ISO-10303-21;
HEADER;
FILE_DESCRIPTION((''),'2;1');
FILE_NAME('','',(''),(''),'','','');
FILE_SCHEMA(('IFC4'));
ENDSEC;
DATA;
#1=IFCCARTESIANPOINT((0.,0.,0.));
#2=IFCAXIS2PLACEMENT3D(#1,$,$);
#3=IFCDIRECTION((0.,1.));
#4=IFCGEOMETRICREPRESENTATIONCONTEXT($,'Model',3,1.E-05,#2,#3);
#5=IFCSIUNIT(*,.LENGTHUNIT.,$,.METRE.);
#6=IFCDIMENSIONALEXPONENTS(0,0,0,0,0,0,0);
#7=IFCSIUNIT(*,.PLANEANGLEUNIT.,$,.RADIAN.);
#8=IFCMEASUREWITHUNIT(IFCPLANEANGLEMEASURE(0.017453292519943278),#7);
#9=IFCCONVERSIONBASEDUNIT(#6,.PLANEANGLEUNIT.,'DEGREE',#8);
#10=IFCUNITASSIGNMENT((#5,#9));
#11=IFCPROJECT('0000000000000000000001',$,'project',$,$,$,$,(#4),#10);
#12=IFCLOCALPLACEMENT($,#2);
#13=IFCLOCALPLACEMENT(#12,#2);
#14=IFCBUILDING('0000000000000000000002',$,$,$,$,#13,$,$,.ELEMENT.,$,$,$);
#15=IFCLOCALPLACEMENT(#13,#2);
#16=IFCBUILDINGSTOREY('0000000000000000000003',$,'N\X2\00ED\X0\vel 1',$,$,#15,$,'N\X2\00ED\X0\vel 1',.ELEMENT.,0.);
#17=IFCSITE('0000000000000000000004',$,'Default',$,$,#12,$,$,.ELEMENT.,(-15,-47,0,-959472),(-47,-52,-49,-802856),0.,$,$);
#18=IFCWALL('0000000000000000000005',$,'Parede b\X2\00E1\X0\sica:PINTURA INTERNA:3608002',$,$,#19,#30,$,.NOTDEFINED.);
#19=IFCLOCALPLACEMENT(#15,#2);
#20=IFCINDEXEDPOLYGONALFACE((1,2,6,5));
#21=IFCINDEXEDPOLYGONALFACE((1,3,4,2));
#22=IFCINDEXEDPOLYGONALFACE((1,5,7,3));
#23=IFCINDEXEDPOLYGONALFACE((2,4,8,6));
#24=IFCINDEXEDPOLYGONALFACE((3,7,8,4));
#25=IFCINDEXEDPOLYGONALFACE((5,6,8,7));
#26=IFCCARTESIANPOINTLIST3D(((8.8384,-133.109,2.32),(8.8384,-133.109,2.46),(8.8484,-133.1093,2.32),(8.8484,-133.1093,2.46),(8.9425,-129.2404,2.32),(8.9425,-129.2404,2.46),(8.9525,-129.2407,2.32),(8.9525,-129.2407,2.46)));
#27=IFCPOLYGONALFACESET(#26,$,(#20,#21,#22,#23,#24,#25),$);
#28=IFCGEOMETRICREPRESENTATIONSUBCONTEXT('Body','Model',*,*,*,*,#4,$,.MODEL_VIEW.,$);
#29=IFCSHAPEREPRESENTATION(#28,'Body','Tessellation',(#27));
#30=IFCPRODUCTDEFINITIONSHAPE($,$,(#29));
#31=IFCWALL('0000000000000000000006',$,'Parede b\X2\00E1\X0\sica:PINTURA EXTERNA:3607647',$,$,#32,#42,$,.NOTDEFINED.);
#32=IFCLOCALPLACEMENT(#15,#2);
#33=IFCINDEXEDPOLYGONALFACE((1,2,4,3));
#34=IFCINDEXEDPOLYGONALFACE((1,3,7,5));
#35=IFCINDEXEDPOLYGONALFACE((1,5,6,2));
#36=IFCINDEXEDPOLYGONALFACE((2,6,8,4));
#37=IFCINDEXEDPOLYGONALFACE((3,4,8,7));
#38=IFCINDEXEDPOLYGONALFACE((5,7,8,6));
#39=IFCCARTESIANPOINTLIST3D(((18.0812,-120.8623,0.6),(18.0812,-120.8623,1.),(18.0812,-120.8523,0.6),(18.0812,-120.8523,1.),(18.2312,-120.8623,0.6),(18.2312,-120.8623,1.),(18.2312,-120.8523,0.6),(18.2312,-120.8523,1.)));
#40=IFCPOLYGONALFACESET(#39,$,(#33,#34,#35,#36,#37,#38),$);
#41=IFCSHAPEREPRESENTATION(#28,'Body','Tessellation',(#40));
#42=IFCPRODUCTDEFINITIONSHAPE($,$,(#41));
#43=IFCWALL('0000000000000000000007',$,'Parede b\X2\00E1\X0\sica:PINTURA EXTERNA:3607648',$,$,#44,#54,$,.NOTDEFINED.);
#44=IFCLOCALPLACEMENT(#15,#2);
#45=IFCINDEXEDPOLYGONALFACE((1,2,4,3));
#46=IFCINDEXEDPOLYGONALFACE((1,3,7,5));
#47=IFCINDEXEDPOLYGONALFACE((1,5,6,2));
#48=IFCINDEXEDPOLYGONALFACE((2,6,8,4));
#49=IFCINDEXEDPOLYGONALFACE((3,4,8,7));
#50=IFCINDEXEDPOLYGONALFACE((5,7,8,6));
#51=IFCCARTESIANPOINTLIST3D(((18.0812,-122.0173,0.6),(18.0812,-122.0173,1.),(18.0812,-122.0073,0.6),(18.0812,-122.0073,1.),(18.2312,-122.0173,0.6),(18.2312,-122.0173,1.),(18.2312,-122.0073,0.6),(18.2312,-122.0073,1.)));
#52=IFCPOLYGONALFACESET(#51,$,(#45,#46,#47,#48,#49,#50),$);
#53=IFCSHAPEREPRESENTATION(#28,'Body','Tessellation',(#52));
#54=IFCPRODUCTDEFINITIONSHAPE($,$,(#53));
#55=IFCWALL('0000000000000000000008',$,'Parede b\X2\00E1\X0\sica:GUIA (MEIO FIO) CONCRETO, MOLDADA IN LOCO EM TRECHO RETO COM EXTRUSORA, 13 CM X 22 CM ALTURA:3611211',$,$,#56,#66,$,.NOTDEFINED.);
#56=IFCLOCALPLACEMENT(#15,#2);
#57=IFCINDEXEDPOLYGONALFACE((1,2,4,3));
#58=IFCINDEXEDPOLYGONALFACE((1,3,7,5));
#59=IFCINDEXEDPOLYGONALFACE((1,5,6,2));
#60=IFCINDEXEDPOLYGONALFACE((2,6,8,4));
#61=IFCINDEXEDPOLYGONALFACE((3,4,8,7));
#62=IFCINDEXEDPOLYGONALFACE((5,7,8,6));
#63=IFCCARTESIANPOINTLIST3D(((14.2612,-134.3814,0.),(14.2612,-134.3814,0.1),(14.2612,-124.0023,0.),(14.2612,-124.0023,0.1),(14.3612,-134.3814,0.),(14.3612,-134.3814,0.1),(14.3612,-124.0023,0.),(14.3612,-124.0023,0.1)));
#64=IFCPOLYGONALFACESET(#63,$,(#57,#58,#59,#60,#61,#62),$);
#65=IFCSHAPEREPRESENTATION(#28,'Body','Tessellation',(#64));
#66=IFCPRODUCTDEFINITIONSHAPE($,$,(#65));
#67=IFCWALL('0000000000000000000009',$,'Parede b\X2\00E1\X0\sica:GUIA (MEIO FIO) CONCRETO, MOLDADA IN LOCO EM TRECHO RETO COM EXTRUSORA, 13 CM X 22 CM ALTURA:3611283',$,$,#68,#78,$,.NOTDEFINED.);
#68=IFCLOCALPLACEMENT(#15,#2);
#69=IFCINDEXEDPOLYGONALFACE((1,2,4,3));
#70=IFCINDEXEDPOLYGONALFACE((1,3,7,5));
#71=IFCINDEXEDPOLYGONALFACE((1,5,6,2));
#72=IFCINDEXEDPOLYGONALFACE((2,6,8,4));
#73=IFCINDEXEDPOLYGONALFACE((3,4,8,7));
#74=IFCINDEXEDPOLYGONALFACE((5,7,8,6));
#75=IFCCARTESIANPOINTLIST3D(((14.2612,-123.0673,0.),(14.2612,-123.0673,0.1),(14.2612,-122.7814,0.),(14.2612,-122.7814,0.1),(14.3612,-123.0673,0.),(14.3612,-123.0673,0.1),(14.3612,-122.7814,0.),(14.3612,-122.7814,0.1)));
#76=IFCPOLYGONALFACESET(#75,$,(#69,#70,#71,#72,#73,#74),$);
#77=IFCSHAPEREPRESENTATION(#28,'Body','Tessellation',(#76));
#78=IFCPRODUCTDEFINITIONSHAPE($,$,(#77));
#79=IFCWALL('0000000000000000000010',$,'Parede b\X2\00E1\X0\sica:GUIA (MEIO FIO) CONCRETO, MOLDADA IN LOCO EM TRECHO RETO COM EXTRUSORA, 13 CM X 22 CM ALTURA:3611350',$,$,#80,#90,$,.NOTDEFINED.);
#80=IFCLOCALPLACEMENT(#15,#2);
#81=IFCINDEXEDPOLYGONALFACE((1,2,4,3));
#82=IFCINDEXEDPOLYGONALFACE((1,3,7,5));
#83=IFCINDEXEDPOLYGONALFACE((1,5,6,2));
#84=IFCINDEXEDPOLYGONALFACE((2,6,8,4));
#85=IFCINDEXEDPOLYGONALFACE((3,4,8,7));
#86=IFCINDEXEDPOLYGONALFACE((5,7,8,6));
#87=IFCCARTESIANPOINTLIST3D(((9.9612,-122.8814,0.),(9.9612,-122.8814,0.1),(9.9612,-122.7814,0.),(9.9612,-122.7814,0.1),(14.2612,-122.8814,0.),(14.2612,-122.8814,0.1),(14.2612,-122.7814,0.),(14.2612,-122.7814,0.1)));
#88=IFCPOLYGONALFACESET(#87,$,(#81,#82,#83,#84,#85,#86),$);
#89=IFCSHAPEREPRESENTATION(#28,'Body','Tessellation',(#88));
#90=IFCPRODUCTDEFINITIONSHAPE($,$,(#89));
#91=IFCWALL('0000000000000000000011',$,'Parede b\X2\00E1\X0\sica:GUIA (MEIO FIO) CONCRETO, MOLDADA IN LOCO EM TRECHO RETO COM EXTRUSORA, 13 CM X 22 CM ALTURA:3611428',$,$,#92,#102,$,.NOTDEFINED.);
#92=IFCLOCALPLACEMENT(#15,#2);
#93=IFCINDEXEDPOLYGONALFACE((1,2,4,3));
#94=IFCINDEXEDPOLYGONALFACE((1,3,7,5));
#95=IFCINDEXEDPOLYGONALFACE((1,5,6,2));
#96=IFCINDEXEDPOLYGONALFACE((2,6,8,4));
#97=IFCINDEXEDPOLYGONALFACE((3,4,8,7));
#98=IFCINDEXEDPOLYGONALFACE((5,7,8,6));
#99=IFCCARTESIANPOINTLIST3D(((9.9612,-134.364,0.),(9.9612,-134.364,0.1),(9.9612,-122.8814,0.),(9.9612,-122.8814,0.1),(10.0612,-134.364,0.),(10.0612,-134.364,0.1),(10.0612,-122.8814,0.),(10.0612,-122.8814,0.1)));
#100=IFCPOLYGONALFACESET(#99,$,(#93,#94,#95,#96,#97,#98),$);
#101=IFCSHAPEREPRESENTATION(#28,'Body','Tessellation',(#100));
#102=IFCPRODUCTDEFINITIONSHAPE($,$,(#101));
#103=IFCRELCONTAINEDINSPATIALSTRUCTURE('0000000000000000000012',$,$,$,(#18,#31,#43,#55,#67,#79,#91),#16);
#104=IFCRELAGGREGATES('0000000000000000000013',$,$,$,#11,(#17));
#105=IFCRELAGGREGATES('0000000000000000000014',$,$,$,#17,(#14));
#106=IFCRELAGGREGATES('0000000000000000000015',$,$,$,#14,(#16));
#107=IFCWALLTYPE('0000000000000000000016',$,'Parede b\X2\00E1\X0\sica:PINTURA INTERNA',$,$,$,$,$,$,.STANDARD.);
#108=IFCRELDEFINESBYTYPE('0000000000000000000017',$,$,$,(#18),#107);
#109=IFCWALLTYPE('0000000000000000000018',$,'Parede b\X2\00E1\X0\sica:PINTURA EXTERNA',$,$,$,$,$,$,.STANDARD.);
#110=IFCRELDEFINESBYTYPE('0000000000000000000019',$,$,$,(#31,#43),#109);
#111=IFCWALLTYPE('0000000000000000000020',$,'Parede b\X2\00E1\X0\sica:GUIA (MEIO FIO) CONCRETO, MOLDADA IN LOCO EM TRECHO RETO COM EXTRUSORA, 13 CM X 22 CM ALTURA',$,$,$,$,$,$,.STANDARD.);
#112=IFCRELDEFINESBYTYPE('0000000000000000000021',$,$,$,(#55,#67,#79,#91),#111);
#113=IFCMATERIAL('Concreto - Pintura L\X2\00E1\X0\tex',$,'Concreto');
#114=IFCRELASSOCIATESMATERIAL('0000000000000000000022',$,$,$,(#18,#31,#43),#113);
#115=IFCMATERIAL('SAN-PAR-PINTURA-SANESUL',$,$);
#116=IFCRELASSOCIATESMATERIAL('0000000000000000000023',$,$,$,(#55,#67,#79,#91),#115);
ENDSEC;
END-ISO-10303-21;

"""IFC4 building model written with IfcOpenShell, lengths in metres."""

from ifc_helpers import new_model, entity, si_unit, converted_unit, direction, frame, origin, place, context, subcontext, project, spatial, indexed_curve, outline, extrude, material, type_object, element, save


model = new_model("IFC4")

# Units and contexts
model_context = context("Model", 3, precision=1e-05, world=origin(), true_north=direction((0.0, 1.0)))
body_context = subcontext(model_context, "Body", "Model", "MODEL_VIEW")
ifc_project = project(units=[si_unit("LENGTHUNIT", "METRE"), converted_unit("PLANEANGLEUNIT", "DEGREE", entity("IfcPlaneAngleMeasure", 0.017453292519943278), si_unit("PLANEANGLEUNIT", "RADIAN"), dimensions=[0, 0, 0, 0, 0, 0, 0])], contexts=[model_context])

# Site, building, storey
site_placement = place(None, origin())
site = spatial("IfcSite", under=ifc_project, at=site_placement, Name="Default", CompositionType="ELEMENT", RefLatitude=(-15, -47, 0, -959472), RefLongitude=(-47, -52, -49, -802856), RefElevation=0.0)
building_placement = place(site_placement, origin())
building = spatial("IfcBuilding", under=site, at=building_placement, CompositionType="ELEMENT")
storey_placement = place(building_placement, origin())
storey = spatial("IfcBuildingStorey", under=building, at=storey_placement, Name="Nível 1", LongName="Nível 1", CompositionType="ELEMENT", Elevation=0.0)

# Shared definitions
ifc_material_1 = material(Name="Concreto - Pintura Látex", Category="Concreto")

# Walls
ifc_material_2 = material(Name="SAN-PAR-PINTURA-SANESUL")
wall_type_1 = type_object("IfcWallType", Name="Parede básica:PINTURA INTERNA", PredefinedType="STANDARD")
wall_1_placement = place(storey_placement, frame((8.8434, -133.1092, 2.32), z_axis=(0.0, 0.0, 1.0), x_axis=(0.026888, 0.999638, 0.0)))
element("IfcWall", 1, at=wall_1_placement, inside=storey, type_object=wall_type_1, material=ifc_material_1, Name="Parede básica:PINTURA INTERNA:3608002", PredefinedType="NOTDEFINED", context=body_context, shape_type="SweptSolid", body=[
    extrude(outline(indexed_curve([(3.87, 0.005), (0.0, 0.005), (0.0, -0.005), (3.87, -0.005), (3.87, 0.005)], self_intersect=False)), origin(), (0.0, 0.0, 1.0), 0.14),
])
wall_type_2 = type_object("IfcWallType", Name="Parede básica:PINTURA EXTERNA", PredefinedType="STANDARD")
wall_2_placement = place(storey_placement, frame((18.0812, -120.8573, 0.6)))
element("IfcWall", 2, at=wall_2_placement, inside=storey, type_object=wall_type_2, material=ifc_material_1, Name="Parede básica:PINTURA EXTERNA:3607647", PredefinedType="NOTDEFINED", context=body_context, shape_type="SweptSolid", body=[
    extrude(outline(indexed_curve([(0.15, 0.005), (0.0, 0.005), (0.0, -0.005), (0.15, -0.005), (0.15, 0.005)], self_intersect=False)), origin(), (0.0, 0.0, 1.0), 0.4),
])
wall_3_placement = place(storey_placement, frame((18.0812, -122.0123, 0.6)))
element("IfcWall", 3, at=wall_3_placement, inside=storey, type_object=wall_type_2, material=ifc_material_1, Name="Parede básica:PINTURA EXTERNA:3607648", PredefinedType="NOTDEFINED", context=body_context, shape_type="SweptSolid", body=[
    extrude(outline(indexed_curve([(0.15, 0.005), (0.0, 0.005), (0.0, -0.005), (0.15, -0.005), (0.15, 0.005)], self_intersect=False)), origin(), (0.0, 0.0, 1.0), 0.4),
])

# Walls
wall_type_3 = type_object("IfcWallType", Name="Parede básica:GUIA (MEIO FIO) CONCRETO, MOLDADA IN LOCO EM TRECHO RETO COM EXTRUSORA, 13 CM X 22 CM ALTURA", PredefinedType="STANDARD")
wall_4_placement = place(storey_placement, frame((14.3112, -134.3814, 0.0), z_axis=(0.0, 0.0, 1.0), x_axis=(0.0, 1.0, 0.0)))
element("IfcWall", 4, at=wall_4_placement, inside=storey, type_object=wall_type_3, material=ifc_material_2, Name="Parede básica:GUIA (MEIO FIO) CONCRETO, MOLDADA IN LOCO EM TRECHO RETO COM EXTRUSORA, 13 CM X 22 CM ALTURA:3611211", PredefinedType="NOTDEFINED", context=body_context, shape_type="SweptSolid", body=[
    extrude(outline(indexed_curve([(10.3791, 0.05), (0.0, 0.05), (0.0, -0.05), (10.3791, -0.05), (10.3791, 0.05)], self_intersect=False)), origin(), (0.0, 0.0, 1.0), 0.1),
])
wall_5_placement = place(storey_placement, frame((14.3112, -123.0673, 0.0), z_axis=(0.0, 0.0, 1.0), x_axis=(0.0, 1.0, 0.0)))
element("IfcWall", 5, at=wall_5_placement, inside=storey, type_object=wall_type_3, material=ifc_material_2, Name="Parede básica:GUIA (MEIO FIO) CONCRETO, MOLDADA IN LOCO EM TRECHO RETO COM EXTRUSORA, 13 CM X 22 CM ALTURA:3611283", PredefinedType="NOTDEFINED", context=body_context, shape_type="SweptSolid", body=[
    extrude(outline(indexed_curve([(0.2859, 0.05), (0.0, 0.05), (0.0, -0.05), (0.2859, -0.05), (0.2859, 0.05)], self_intersect=False)), origin(), (0.0, 0.0, 1.0), 0.1),
])
wall_6_placement = place(storey_placement, frame((14.2612, -122.8314, 0.0), z_axis=(0.0, 0.0, 1.0), x_axis=(-1.0, 0.0, 0.0)))
element("IfcWall", 6, at=wall_6_placement, inside=storey, type_object=wall_type_3, material=ifc_material_2, Name="Parede básica:GUIA (MEIO FIO) CONCRETO, MOLDADA IN LOCO EM TRECHO RETO COM EXTRUSORA, 13 CM X 22 CM ALTURA:3611350", PredefinedType="NOTDEFINED", context=body_context, shape_type="SweptSolid", body=[
    extrude(outline(indexed_curve([(4.3, 0.05), (0.0, 0.05), (0.0, -0.05), (4.3, -0.05), (4.3, 0.05)], self_intersect=False)), origin(), (0.0, 0.0, 1.0), 0.1),
])
wall_7_placement = place(storey_placement, frame((10.0112, -122.8814, 0.0), z_axis=(0.0, 0.0, 1.0), x_axis=(0.0, -1.0, 0.0)))
element("IfcWall", 7, at=wall_7_placement, inside=storey, type_object=wall_type_3, material=ifc_material_2, Name="Parede básica:GUIA (MEIO FIO) CONCRETO, MOLDADA IN LOCO EM TRECHO RETO COM EXTRUSORA, 13 CM X 22 CM ALTURA:3611428", PredefinedType="NOTDEFINED", context=body_context, shape_type="SweptSolid", body=[
    extrude(outline(indexed_curve([(11.4826, 0.05), (0.0, 0.05), (0.0, -0.05), (11.4826, -0.05), (11.4826, 0.05)], self_intersect=False)), origin(), (0.0, 0.0, 1.0), 0.1),
])

save(model, "model.ifc")
